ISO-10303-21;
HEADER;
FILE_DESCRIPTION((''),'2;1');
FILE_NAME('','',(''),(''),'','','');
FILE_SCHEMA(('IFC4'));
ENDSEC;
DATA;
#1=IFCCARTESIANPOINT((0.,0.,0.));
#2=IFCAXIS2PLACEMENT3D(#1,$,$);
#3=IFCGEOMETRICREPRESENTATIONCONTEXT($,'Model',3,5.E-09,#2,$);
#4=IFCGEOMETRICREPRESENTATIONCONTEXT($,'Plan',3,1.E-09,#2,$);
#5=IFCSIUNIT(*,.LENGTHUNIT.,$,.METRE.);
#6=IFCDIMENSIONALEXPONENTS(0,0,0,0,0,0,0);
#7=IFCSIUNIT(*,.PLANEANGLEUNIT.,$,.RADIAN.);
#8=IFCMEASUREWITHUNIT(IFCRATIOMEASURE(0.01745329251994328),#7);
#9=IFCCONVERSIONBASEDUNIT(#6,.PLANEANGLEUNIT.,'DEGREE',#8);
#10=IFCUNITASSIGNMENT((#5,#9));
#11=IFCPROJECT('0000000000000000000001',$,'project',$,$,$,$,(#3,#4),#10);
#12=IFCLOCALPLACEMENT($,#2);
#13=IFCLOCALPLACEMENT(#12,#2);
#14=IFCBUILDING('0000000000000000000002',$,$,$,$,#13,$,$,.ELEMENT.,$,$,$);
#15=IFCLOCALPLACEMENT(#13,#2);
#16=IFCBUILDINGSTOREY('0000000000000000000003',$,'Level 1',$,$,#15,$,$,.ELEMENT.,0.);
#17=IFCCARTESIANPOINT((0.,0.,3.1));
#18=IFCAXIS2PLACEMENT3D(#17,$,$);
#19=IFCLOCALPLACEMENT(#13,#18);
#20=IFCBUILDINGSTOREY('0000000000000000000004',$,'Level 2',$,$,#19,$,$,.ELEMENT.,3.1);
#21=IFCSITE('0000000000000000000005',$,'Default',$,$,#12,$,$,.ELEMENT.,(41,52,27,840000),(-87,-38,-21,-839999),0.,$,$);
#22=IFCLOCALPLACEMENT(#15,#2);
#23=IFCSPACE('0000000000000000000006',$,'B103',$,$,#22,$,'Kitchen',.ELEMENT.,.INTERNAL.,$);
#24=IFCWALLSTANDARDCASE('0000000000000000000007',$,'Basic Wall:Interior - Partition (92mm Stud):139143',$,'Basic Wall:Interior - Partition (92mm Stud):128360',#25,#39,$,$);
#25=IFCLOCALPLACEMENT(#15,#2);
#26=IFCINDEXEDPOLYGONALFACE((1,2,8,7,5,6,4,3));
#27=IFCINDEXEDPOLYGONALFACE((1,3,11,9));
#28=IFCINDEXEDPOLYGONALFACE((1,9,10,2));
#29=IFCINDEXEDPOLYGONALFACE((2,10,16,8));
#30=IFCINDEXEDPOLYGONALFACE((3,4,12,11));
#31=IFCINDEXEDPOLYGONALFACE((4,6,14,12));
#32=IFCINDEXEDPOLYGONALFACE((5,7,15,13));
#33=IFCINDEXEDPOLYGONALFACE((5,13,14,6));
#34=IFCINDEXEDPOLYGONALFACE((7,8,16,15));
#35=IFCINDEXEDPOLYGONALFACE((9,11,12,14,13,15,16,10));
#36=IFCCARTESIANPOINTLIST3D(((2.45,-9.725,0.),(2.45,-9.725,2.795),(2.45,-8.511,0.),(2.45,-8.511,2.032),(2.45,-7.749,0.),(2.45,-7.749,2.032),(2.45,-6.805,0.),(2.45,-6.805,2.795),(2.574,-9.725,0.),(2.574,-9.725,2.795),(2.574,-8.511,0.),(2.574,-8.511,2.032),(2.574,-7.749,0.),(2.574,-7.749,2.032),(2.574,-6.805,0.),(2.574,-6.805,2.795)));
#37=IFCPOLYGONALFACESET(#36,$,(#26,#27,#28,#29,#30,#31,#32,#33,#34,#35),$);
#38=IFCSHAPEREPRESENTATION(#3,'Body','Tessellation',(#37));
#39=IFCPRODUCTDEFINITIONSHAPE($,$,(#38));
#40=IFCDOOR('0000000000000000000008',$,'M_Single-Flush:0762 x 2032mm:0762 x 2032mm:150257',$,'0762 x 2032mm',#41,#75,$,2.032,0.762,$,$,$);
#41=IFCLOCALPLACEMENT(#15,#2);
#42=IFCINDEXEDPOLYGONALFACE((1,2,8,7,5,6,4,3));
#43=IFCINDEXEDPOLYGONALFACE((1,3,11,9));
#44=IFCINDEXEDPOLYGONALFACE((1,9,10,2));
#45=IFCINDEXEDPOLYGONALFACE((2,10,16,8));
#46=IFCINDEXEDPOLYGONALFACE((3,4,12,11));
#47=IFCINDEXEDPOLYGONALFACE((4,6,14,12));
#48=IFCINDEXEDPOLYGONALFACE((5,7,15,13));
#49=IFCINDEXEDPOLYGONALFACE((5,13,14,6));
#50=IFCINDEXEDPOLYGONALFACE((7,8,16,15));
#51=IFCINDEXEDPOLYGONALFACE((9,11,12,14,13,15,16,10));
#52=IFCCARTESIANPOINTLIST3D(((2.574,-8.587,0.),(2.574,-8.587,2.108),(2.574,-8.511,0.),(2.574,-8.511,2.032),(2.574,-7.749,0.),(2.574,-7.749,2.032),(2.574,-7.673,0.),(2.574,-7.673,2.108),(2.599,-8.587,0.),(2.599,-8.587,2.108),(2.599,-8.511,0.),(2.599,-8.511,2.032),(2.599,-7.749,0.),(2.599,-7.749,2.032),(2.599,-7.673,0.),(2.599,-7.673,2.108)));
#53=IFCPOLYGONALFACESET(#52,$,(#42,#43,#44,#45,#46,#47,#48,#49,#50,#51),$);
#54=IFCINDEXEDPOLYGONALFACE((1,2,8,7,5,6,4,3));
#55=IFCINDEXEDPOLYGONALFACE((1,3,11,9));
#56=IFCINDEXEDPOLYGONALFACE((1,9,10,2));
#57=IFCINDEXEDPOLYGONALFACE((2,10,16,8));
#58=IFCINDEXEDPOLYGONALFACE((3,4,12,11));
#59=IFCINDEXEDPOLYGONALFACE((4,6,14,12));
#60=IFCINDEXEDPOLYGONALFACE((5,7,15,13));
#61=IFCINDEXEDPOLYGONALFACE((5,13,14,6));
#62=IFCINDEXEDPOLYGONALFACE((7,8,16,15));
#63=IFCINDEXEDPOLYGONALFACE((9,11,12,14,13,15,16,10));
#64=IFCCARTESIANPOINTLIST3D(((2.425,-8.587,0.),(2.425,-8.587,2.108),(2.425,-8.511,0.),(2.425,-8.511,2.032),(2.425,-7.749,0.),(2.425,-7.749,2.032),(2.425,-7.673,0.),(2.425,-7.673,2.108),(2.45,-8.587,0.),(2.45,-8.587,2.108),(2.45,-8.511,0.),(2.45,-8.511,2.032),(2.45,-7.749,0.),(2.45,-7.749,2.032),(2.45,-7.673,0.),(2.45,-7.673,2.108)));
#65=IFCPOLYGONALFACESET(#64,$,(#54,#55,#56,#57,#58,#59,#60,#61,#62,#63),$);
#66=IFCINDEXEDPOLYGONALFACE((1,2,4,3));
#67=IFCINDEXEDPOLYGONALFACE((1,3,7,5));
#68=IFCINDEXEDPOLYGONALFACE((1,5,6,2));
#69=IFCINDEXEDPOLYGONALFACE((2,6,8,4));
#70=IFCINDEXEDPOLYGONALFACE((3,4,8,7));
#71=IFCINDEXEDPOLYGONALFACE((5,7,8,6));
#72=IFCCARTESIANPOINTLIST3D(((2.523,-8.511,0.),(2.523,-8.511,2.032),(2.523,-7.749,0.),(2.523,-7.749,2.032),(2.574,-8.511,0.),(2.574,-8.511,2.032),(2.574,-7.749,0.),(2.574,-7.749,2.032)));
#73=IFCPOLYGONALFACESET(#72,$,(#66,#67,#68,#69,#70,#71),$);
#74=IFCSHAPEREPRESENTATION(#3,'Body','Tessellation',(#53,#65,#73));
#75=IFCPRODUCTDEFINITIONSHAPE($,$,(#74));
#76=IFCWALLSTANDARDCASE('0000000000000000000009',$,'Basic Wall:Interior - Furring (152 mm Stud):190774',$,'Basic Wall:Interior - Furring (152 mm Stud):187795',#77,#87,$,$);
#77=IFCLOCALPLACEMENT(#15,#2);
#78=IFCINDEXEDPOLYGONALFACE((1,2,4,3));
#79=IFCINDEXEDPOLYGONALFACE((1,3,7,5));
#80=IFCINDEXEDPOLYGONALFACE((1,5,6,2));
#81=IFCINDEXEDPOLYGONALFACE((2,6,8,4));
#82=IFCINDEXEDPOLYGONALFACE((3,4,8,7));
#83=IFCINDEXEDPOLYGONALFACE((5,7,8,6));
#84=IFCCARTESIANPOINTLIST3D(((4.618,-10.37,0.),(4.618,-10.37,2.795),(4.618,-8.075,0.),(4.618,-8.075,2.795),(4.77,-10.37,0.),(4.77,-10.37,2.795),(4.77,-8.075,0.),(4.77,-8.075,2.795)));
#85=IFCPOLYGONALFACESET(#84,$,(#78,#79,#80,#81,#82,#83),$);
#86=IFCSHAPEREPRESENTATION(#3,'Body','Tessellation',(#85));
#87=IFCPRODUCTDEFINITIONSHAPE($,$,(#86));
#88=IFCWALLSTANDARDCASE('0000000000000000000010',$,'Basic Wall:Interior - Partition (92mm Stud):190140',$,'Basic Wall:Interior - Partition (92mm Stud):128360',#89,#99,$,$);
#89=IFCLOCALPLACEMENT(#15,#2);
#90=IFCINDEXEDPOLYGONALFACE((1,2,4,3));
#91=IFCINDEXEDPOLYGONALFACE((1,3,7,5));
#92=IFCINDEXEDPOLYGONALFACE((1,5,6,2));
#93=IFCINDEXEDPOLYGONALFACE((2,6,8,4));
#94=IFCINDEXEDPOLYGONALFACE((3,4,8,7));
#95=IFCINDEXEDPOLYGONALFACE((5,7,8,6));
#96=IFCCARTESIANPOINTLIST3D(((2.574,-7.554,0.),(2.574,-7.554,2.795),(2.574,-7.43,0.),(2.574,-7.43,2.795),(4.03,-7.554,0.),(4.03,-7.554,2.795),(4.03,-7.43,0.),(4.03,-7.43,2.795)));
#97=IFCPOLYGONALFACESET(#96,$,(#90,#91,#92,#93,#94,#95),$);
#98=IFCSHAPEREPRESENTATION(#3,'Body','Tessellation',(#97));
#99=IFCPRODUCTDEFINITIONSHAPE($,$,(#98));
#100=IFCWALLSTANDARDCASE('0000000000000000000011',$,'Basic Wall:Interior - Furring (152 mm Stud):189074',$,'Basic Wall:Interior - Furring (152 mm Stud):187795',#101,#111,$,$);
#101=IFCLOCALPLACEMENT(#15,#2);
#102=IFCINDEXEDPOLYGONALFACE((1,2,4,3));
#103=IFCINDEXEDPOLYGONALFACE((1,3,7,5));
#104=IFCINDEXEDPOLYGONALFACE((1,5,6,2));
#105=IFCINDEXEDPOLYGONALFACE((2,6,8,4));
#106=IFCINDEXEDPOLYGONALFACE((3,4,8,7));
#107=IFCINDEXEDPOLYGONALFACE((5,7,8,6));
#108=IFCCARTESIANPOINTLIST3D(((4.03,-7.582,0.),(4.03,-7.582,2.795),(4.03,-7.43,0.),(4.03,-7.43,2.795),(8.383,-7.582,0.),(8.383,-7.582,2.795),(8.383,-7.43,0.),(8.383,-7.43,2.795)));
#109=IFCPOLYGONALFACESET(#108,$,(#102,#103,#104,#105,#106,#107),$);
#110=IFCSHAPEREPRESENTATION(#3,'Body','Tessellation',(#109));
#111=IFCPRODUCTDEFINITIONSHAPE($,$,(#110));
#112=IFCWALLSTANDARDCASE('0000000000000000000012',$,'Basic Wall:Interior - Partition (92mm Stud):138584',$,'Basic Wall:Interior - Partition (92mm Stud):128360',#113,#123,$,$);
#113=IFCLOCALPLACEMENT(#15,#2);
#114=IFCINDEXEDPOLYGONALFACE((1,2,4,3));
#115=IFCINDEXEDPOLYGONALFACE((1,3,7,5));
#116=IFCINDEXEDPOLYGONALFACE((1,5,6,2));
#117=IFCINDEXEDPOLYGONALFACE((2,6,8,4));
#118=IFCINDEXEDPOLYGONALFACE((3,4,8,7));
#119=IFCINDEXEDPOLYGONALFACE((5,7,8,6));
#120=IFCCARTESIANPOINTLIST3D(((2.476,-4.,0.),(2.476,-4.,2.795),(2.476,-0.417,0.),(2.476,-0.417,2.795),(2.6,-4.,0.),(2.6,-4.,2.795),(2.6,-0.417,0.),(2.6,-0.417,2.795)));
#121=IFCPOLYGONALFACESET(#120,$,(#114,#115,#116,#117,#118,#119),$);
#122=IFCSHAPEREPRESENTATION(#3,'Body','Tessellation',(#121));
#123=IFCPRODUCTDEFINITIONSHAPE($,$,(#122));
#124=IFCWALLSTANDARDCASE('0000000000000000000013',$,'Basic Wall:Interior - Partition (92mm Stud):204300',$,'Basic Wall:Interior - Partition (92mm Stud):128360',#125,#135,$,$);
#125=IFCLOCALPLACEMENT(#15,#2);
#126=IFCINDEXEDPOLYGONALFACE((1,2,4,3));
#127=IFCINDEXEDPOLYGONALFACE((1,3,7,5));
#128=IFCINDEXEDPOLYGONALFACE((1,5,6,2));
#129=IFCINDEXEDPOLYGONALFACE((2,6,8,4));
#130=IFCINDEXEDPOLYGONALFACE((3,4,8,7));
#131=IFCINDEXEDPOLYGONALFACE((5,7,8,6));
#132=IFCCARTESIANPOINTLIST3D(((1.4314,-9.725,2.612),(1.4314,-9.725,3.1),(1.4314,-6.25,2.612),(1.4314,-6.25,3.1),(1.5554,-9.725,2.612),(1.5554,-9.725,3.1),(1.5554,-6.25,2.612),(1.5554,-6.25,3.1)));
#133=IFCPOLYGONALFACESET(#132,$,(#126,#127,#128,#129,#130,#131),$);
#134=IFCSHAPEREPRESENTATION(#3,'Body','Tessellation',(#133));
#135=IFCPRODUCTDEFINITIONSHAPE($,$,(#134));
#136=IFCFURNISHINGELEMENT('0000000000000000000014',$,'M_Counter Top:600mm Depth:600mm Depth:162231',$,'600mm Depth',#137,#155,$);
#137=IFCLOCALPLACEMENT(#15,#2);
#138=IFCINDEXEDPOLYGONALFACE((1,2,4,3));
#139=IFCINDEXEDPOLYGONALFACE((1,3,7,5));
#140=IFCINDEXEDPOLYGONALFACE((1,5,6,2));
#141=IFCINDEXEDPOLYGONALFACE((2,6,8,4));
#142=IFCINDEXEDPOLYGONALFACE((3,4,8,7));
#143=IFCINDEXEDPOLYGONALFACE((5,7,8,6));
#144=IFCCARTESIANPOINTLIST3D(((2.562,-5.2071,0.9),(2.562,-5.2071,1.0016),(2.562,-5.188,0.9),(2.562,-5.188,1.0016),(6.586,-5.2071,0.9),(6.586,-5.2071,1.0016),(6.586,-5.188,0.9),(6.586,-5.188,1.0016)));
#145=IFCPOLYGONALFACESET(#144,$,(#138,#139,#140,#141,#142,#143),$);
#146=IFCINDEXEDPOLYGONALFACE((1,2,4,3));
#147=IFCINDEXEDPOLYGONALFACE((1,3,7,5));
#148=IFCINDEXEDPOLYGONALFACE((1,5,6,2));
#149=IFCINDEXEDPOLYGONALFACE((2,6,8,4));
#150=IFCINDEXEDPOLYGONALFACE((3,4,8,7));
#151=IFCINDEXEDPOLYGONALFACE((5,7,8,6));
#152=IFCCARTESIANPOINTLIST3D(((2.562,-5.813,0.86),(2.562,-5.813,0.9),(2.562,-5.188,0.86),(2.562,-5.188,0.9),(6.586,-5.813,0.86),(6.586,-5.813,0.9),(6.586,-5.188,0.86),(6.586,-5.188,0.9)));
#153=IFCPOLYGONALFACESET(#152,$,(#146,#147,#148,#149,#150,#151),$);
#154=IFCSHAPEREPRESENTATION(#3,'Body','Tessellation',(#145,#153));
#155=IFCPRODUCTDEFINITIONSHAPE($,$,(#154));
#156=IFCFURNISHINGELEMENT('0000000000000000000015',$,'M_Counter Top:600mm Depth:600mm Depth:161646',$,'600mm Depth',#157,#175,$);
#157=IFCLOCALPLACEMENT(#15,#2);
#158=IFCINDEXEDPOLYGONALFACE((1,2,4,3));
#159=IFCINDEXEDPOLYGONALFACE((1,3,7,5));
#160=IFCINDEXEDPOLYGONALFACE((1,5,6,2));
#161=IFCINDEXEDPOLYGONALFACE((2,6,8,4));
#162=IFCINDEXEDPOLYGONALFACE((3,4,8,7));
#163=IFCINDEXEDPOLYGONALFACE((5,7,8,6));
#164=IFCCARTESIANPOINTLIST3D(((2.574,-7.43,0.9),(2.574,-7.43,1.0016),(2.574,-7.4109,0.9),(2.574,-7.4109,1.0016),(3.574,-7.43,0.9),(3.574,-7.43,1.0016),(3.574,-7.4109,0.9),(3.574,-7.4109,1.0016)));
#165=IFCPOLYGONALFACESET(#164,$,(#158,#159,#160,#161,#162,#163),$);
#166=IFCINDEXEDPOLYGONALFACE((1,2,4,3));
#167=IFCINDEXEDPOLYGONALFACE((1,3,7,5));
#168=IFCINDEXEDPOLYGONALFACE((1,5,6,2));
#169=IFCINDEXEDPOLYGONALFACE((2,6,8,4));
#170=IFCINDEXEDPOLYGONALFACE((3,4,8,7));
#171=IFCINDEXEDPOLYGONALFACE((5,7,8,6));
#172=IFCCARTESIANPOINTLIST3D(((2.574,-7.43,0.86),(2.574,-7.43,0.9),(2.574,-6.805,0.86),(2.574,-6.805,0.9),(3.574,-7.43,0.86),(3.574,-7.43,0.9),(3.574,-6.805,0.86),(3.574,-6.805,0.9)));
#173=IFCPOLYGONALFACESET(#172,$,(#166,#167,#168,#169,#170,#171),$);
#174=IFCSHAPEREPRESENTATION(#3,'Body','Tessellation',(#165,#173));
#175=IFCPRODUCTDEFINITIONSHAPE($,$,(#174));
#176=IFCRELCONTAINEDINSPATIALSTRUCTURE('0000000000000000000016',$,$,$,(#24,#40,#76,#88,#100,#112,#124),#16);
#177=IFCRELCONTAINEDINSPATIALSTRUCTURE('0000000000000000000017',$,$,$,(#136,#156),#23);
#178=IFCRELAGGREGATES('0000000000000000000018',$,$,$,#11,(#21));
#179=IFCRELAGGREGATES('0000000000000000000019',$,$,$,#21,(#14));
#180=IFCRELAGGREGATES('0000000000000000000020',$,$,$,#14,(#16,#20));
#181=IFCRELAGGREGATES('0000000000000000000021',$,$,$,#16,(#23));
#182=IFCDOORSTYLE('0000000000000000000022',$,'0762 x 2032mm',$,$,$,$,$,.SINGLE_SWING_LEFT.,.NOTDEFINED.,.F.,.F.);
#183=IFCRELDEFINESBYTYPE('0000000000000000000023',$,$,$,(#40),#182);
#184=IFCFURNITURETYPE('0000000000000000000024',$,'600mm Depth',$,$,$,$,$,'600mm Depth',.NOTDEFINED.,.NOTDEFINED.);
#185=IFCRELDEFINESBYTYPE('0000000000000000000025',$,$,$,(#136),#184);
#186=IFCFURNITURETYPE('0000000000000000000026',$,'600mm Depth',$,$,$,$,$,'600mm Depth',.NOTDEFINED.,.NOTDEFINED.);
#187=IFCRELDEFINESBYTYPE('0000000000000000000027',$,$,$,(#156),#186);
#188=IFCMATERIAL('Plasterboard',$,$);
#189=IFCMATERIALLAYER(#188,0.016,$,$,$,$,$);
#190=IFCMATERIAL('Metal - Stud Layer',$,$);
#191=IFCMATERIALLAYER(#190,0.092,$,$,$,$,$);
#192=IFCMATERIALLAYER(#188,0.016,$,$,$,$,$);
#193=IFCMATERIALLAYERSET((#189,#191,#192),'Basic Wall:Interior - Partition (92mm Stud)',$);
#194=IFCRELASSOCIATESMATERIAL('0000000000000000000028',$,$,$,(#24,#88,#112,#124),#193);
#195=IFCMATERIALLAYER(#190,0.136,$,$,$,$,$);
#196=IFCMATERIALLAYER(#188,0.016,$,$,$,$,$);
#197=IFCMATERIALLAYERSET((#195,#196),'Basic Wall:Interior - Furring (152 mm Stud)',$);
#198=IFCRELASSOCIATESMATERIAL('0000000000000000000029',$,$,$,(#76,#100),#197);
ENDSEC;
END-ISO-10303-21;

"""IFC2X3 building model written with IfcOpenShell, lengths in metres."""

from ifc_helpers import new_model, entity, si_unit, converted_unit, frame, frame_2d, origin, origin_2d_with_axis, place, context, project, spatial, polyline, rectangle, outline, extrude, clip, bounded_halfspace, source, transform, mapped, material, layer, layer_set, layer_usage, type_object, type_shapes, element, fill, save


model = new_model("IFC2X3")

# Units and contexts
model_context = context("Model", 3, precision=5e-09, world=origin())
plan_context = context("Plan", 3, precision=1e-09, world=origin())
ifc_project = project(units=[si_unit("LENGTHUNIT", "METRE"), converted_unit("PLANEANGLEUNIT", "DEGREE", entity("IfcRatioMeasure", 0.01745329251994328), si_unit("PLANEANGLEUNIT", "RADIAN"), dimensions=[0, 0, 0, 0, 0, 0, 0])], contexts=[model_context, plan_context])

# Site, building, storey
site_placement = place(None, origin())
site = spatial("IfcSite", under=ifc_project, at=site_placement, Name="Default", CompositionType="ELEMENT", RefLatitude=(41, 52, 27, 840000), RefLongitude=(-87, -38, -21, -839999), RefElevation=0.0)
building_placement = place(site_placement, origin())
building = spatial("IfcBuilding", under=site, at=building_placement, CompositionType="ELEMENT")
storey_1_placement = place(building_placement, origin())
storey_1 = spatial("IfcBuildingStorey", under=building, at=storey_1_placement, Name="Level 1", CompositionType="ELEMENT", Elevation=0.0)

# Shared definitions
ifc_material_1 = material(Name="Metal - Stud Layer")
ifc_material_2 = material(Name="Plasterboard")

# Shared definitions
ifc_layer_1 = layer(ifc_material_2, 0.016)
ifc_layer_2 = layer(ifc_material_1, 0.092)
ifc_layer_3 = layer(ifc_material_2, 0.016)
ifc_layer_set_1 = layer_set([ifc_layer_1, ifc_layer_2, ifc_layer_3], Name="Basic Wall:Interior - Partition (92mm Stud)")
ifc_layer_usage_1 = layer_usage(ifc_layer_set_1, "AXIS2", "NEGATIVE", 0.062)

# Shared definitions
storey_2_placement = place(building_placement, frame((0.0, 0.0, 3.1)))
storey_2 = spatial("IfcBuildingStorey", under=building, at=storey_2_placement, Name="Level 2", CompositionType="ELEMENT", Elevation=3.1)

# Wall, opening, door
wall_1_placement = place(storey_1_placement, frame((2.512, -6.805, 0.0), z_axis=(0.0, 0.0, 1.0), x_axis=(0.0, -1.0, 0.0)))
wall_1 = element("IfcWallStandardCase", 1, at=wall_1_placement, inside=storey_1, material=ifc_layer_usage_1, Name="Basic Wall:Interior - Partition (92mm Stud):139143", ObjectType="Basic Wall:Interior - Partition (92mm Stud):128360", context=model_context, shape_type="SweptSolid", body=[
    extrude(rectangle(XDim=2.92, YDim=0.124, at=frame_2d((1.46, 0.0), x_axis=(-1.0, 0.0))), origin(), (0.0, 0.0, 1.0), 2.795),
])
opening_1_placement = place(wall_1_placement, frame((0.944, -0.062, 0.0)))
opening_1 = element("IfcOpeningElement", 2, at=opening_1_placement, cuts=wall_1, ObjectType="Opening", context=model_context, shape_type="SweptSolid", body=[
    extrude(rectangle(XDim=0.762, YDim=2.032, at=frame_2d((1.016, 0.381), x_axis=(0.0, -1.0))), frame((0.0, 0.0, 0.0), z_axis=(0.0, 1.0, 0.0), x_axis=(0.0, 0.0, 1.0)), (0.0, 0.0, 1.0), 0.124),
])
door_style_1 = type_object("IfcDoorStyle", Name="0762 x 2032mm", ConstructionType="NOTDEFINED", OperationType="SINGLE_SWING_LEFT", ParameterTakesPrecedence=False, Sizeable=False)
shared_shape_1 = source(origin(), model_context, "Body", "SweptSolid", [
    extrude(outline(polyline([(-0.457, -1.073), (0.457, -1.073), (0.457, 1.035), (0.381, 1.035), (0.381, -0.997), (-0.381, -0.997), (-0.381, 1.035), (-0.457, 1.035), (-0.457, -1.073)])), frame((0.381, 0.149, 1.035), z_axis=(0.0, -1.0, 0.0), x_axis=(-1.0, 0.0, 0.0)), (0.0, 0.0, 1.0), 0.025),
    extrude(outline(polyline([(-1.073, -0.457), (1.035, -0.457), (1.035, -0.381), (-0.997, -0.381), (-0.997, 0.381), (1.035, 0.381), (1.035, 0.457), (-1.073, 0.457), (-1.073, -0.457)])), frame((0.381, 0.0, 1.035), z_axis=(0.0, -1.0, 0.0), x_axis=(0.0, 0.0, -1.0)), (0.0, 0.0, 1.0), 0.025),
    extrude(rectangle(XDim=0.762, YDim=0.051, at=origin_2d_with_axis()), frame((0.381, 0.0985, 0.0)), (0.0, 0.0, 1.0), 2.032),
])
type_shapes(door_style_1, [shared_shape_1])
door_1_placement = place(opening_1_placement, origin())
door_1 = element("IfcDoor", 3, at=door_1_placement, inside=storey_1, type_object=door_style_1, Name="M_Single-Flush:0762 x 2032mm:0762 x 2032mm:150257", ObjectType="0762 x 2032mm", OverallHeight=2.032, OverallWidth=0.762, context=model_context, shape_type="MappedRepresentation", body=[
    mapped(shared_shape_1, transform((0.0, 0.0, 0.0), scale=1.0)),
])
fill(opening_1, door_1)

# Walls
ifc_layer_4 = layer(ifc_material_1, 0.136)
ifc_layer_5 = layer(ifc_material_2, 0.016)
ifc_layer_set_2 = layer_set([ifc_layer_4, ifc_layer_5], Name="Basic Wall:Interior - Furring (152 mm Stud)")
ifc_layer_usage_2 = layer_usage(ifc_layer_set_2, "AXIS2", "POSITIVE", -0.076)
wall_2_placement = place(storey_1_placement, frame((4.694, -8.075, 0.0), z_axis=(0.0, 0.0, 1.0), x_axis=(0.0, -1.0, 0.0)))
element("IfcWallStandardCase", 4, at=wall_2_placement, inside=storey_1, material=ifc_layer_usage_2, Name="Basic Wall:Interior - Furring (152 mm Stud):190774", ObjectType="Basic Wall:Interior - Furring (152 mm Stud):187795", context=model_context, shape_type="SweptSolid", body=[
    extrude(rectangle(XDim=2.295, YDim=0.152, at=frame_2d((1.1475, 0.0), x_axis=(-1.0, 0.0))), origin(), (0.0, 0.0, 1.0), 2.795),
])
wall_3_placement = place(storey_1_placement, frame((4.03, -7.492, 0.0), z_axis=(0.0, 0.0, 1.0), x_axis=(-1.0, 0.0, 0.0)))
element("IfcWallStandardCase", 5, at=wall_3_placement, inside=storey_1, material=ifc_layer_usage_1, Name="Basic Wall:Interior - Partition (92mm Stud):190140", ObjectType="Basic Wall:Interior - Partition (92mm Stud):128360", context=model_context, shape_type="SweptSolid", body=[
    extrude(rectangle(XDim=1.456, YDim=0.124, at=frame_2d((0.728, 0.0), x_axis=(-1.0, 0.0))), origin(), (0.0, 0.0, 1.0), 2.795),
])
ifc_layer_usage_3 = layer_usage(ifc_layer_set_2, "AXIS2", "NEGATIVE", 0.076)
wall_4_placement = place(storey_1_placement, frame((8.383, -7.506, 0.0), z_axis=(0.0, 0.0, 1.0), x_axis=(-1.0, 0.0, 0.0)))
element("IfcWallStandardCase", 6, at=wall_4_placement, inside=storey_1, material=ifc_layer_usage_3, Name="Basic Wall:Interior - Furring (152 mm Stud):189074", ObjectType="Basic Wall:Interior - Furring (152 mm Stud):187795", context=model_context, shape_type="Clipping", body=[
    clip(extrude(rectangle(XDim=4.353, YDim=0.152, at=frame_2d((2.1765, 0.0), x_axis=(-1.0, 0.0))), origin(), (0.0, 0.0, 1.0), 2.795), bounded_halfspace(frame((0.0, -0.076, 2.795), z_axis=(0.0, 0.0, -1.0), x_axis=(0.0, 1.0, 0.0)), True, frame((0.0, -0.076, 2.795)), polyline([(0.0, 0.0), (3.708, 0.0), (3.708, 0.152), (0.0, 0.152), (0.0, 0.0)]))),
])
wall_5_placement = place(storey_1_placement, frame((2.538, -0.417, 0.0), z_axis=(0.0, 0.0, 1.0), x_axis=(0.0, -1.0, 0.0)))
element("IfcWallStandardCase", 7, at=wall_5_placement, inside=storey_1, material=ifc_layer_usage_1, Name="Basic Wall:Interior - Partition (92mm Stud):138584", ObjectType="Basic Wall:Interior - Partition (92mm Stud):128360", context=model_context, shape_type="SweptSolid", body=[
    extrude(rectangle(XDim=3.583, YDim=0.124, at=frame_2d((1.7915, 0.0), x_axis=(-1.0, 0.0))), origin(), (0.0, 0.0, 1.0), 2.795),
])
wall_6_placement = place(storey_1_placement, frame((1.4934, -6.25, 2.612), z_axis=(0.0, 0.0, 1.0), x_axis=(0.0, -1.0, 0.0)))
element("IfcWallStandardCase", 8, at=wall_6_placement, inside=storey_1, material=ifc_layer_usage_1, Name="Basic Wall:Interior - Partition (92mm Stud):204300", ObjectType="Basic Wall:Interior - Partition (92mm Stud):128360", context=model_context, shape_type="SweptSolid", body=[
    extrude(rectangle(XDim=3.475, YDim=0.124, at=frame_2d((1.7375, 0.0), x_axis=(-1.0, 0.0))), origin(), (0.0, 0.0, 1.0), 0.488),
])

# Shared definitions
space_1_placement = place(storey_1_placement, origin())
space_1 = spatial("IfcSpace", under=storey_1, at=space_1_placement, Name="B103", LongName="Kitchen", CompositionType="ELEMENT", InteriorOrExteriorSpace="INTERNAL")

# Furnishing elements
furniture_type_1 = type_object("IfcFurnitureType", Name="600mm Depth", ElementType="600mm Depth", AssemblyPlace="NOTDEFINED")
shared_shape_2 = source(origin(), model_context, "Body", "SweptSolid", [
    extrude(rectangle(XDim=0.0191, YDim=4.024, at=origin_2d_with_axis()), frame((0.8115, -0.0095, 0.9), z_axis=(0.0, 0.0, 1.0), x_axis=(0.0, -1.0, 0.0)), (0.0, 0.0, 1.0), 0.1016),
    extrude(rectangle(XDim=4.024, YDim=0.625, at=origin_2d_with_axis()), frame((0.8115, -0.3125, 0.86), z_axis=(0.0, 0.0, 1.0), x_axis=(-1.0, 0.0, 0.0)), (0.0, 0.0, 1.0), 0.04),
])
type_shapes(furniture_type_1, [shared_shape_2])
furnishing_1_placement = place(space_1_placement, frame((3.7625, -5.188, 0.0)))
element("IfcFurnishingElement", 9, at=furnishing_1_placement, inside=space_1, type_object=furniture_type_1, Name="M_Counter Top:600mm Depth:600mm Depth:162231", ObjectType="600mm Depth", context=model_context, shape_type="MappedRepresentation", body=[
    mapped(shared_shape_2, transform((0.0, 0.0, 0.0), scale=1.0)),
])
furniture_type_2 = type_object("IfcFurnitureType", Name="600mm Depth", ElementType="600mm Depth", AssemblyPlace="NOTDEFINED")
shared_shape_3 = source(origin(), model_context, "Body", "SweptSolid", [
    extrude(rectangle(XDim=0.0191, YDim=1.0, at=origin_2d_with_axis()), frame((-0.7005, -0.0095, 0.9), z_axis=(0.0, 0.0, 1.0), x_axis=(0.0, -1.0, 0.0)), (0.0, 0.0, 1.0), 0.1016),
    extrude(rectangle(XDim=1.0, YDim=0.625, at=origin_2d_with_axis()), frame((-0.7005, -0.3125, 0.86), z_axis=(0.0, 0.0, 1.0), x_axis=(-1.0, 0.0, 0.0)), (0.0, 0.0, 1.0), 0.04),
])
type_shapes(furniture_type_2, [shared_shape_3])
furnishing_2_placement = place(space_1_placement, frame((2.3735, -7.43, 0.0), z_axis=(0.0, 0.0, 1.0), x_axis=(-1.0, 0.0, 0.0)))
element("IfcFurnishingElement", 10, at=furnishing_2_placement, inside=space_1, type_object=furniture_type_2, Name="M_Counter Top:600mm Depth:600mm Depth:161646", ObjectType="600mm Depth", context=model_context, shape_type="MappedRepresentation", body=[
    mapped(shared_shape_3, transform((0.0, 0.0, 0.0), scale=1.0)),
])

save(model, "model.ifc")
